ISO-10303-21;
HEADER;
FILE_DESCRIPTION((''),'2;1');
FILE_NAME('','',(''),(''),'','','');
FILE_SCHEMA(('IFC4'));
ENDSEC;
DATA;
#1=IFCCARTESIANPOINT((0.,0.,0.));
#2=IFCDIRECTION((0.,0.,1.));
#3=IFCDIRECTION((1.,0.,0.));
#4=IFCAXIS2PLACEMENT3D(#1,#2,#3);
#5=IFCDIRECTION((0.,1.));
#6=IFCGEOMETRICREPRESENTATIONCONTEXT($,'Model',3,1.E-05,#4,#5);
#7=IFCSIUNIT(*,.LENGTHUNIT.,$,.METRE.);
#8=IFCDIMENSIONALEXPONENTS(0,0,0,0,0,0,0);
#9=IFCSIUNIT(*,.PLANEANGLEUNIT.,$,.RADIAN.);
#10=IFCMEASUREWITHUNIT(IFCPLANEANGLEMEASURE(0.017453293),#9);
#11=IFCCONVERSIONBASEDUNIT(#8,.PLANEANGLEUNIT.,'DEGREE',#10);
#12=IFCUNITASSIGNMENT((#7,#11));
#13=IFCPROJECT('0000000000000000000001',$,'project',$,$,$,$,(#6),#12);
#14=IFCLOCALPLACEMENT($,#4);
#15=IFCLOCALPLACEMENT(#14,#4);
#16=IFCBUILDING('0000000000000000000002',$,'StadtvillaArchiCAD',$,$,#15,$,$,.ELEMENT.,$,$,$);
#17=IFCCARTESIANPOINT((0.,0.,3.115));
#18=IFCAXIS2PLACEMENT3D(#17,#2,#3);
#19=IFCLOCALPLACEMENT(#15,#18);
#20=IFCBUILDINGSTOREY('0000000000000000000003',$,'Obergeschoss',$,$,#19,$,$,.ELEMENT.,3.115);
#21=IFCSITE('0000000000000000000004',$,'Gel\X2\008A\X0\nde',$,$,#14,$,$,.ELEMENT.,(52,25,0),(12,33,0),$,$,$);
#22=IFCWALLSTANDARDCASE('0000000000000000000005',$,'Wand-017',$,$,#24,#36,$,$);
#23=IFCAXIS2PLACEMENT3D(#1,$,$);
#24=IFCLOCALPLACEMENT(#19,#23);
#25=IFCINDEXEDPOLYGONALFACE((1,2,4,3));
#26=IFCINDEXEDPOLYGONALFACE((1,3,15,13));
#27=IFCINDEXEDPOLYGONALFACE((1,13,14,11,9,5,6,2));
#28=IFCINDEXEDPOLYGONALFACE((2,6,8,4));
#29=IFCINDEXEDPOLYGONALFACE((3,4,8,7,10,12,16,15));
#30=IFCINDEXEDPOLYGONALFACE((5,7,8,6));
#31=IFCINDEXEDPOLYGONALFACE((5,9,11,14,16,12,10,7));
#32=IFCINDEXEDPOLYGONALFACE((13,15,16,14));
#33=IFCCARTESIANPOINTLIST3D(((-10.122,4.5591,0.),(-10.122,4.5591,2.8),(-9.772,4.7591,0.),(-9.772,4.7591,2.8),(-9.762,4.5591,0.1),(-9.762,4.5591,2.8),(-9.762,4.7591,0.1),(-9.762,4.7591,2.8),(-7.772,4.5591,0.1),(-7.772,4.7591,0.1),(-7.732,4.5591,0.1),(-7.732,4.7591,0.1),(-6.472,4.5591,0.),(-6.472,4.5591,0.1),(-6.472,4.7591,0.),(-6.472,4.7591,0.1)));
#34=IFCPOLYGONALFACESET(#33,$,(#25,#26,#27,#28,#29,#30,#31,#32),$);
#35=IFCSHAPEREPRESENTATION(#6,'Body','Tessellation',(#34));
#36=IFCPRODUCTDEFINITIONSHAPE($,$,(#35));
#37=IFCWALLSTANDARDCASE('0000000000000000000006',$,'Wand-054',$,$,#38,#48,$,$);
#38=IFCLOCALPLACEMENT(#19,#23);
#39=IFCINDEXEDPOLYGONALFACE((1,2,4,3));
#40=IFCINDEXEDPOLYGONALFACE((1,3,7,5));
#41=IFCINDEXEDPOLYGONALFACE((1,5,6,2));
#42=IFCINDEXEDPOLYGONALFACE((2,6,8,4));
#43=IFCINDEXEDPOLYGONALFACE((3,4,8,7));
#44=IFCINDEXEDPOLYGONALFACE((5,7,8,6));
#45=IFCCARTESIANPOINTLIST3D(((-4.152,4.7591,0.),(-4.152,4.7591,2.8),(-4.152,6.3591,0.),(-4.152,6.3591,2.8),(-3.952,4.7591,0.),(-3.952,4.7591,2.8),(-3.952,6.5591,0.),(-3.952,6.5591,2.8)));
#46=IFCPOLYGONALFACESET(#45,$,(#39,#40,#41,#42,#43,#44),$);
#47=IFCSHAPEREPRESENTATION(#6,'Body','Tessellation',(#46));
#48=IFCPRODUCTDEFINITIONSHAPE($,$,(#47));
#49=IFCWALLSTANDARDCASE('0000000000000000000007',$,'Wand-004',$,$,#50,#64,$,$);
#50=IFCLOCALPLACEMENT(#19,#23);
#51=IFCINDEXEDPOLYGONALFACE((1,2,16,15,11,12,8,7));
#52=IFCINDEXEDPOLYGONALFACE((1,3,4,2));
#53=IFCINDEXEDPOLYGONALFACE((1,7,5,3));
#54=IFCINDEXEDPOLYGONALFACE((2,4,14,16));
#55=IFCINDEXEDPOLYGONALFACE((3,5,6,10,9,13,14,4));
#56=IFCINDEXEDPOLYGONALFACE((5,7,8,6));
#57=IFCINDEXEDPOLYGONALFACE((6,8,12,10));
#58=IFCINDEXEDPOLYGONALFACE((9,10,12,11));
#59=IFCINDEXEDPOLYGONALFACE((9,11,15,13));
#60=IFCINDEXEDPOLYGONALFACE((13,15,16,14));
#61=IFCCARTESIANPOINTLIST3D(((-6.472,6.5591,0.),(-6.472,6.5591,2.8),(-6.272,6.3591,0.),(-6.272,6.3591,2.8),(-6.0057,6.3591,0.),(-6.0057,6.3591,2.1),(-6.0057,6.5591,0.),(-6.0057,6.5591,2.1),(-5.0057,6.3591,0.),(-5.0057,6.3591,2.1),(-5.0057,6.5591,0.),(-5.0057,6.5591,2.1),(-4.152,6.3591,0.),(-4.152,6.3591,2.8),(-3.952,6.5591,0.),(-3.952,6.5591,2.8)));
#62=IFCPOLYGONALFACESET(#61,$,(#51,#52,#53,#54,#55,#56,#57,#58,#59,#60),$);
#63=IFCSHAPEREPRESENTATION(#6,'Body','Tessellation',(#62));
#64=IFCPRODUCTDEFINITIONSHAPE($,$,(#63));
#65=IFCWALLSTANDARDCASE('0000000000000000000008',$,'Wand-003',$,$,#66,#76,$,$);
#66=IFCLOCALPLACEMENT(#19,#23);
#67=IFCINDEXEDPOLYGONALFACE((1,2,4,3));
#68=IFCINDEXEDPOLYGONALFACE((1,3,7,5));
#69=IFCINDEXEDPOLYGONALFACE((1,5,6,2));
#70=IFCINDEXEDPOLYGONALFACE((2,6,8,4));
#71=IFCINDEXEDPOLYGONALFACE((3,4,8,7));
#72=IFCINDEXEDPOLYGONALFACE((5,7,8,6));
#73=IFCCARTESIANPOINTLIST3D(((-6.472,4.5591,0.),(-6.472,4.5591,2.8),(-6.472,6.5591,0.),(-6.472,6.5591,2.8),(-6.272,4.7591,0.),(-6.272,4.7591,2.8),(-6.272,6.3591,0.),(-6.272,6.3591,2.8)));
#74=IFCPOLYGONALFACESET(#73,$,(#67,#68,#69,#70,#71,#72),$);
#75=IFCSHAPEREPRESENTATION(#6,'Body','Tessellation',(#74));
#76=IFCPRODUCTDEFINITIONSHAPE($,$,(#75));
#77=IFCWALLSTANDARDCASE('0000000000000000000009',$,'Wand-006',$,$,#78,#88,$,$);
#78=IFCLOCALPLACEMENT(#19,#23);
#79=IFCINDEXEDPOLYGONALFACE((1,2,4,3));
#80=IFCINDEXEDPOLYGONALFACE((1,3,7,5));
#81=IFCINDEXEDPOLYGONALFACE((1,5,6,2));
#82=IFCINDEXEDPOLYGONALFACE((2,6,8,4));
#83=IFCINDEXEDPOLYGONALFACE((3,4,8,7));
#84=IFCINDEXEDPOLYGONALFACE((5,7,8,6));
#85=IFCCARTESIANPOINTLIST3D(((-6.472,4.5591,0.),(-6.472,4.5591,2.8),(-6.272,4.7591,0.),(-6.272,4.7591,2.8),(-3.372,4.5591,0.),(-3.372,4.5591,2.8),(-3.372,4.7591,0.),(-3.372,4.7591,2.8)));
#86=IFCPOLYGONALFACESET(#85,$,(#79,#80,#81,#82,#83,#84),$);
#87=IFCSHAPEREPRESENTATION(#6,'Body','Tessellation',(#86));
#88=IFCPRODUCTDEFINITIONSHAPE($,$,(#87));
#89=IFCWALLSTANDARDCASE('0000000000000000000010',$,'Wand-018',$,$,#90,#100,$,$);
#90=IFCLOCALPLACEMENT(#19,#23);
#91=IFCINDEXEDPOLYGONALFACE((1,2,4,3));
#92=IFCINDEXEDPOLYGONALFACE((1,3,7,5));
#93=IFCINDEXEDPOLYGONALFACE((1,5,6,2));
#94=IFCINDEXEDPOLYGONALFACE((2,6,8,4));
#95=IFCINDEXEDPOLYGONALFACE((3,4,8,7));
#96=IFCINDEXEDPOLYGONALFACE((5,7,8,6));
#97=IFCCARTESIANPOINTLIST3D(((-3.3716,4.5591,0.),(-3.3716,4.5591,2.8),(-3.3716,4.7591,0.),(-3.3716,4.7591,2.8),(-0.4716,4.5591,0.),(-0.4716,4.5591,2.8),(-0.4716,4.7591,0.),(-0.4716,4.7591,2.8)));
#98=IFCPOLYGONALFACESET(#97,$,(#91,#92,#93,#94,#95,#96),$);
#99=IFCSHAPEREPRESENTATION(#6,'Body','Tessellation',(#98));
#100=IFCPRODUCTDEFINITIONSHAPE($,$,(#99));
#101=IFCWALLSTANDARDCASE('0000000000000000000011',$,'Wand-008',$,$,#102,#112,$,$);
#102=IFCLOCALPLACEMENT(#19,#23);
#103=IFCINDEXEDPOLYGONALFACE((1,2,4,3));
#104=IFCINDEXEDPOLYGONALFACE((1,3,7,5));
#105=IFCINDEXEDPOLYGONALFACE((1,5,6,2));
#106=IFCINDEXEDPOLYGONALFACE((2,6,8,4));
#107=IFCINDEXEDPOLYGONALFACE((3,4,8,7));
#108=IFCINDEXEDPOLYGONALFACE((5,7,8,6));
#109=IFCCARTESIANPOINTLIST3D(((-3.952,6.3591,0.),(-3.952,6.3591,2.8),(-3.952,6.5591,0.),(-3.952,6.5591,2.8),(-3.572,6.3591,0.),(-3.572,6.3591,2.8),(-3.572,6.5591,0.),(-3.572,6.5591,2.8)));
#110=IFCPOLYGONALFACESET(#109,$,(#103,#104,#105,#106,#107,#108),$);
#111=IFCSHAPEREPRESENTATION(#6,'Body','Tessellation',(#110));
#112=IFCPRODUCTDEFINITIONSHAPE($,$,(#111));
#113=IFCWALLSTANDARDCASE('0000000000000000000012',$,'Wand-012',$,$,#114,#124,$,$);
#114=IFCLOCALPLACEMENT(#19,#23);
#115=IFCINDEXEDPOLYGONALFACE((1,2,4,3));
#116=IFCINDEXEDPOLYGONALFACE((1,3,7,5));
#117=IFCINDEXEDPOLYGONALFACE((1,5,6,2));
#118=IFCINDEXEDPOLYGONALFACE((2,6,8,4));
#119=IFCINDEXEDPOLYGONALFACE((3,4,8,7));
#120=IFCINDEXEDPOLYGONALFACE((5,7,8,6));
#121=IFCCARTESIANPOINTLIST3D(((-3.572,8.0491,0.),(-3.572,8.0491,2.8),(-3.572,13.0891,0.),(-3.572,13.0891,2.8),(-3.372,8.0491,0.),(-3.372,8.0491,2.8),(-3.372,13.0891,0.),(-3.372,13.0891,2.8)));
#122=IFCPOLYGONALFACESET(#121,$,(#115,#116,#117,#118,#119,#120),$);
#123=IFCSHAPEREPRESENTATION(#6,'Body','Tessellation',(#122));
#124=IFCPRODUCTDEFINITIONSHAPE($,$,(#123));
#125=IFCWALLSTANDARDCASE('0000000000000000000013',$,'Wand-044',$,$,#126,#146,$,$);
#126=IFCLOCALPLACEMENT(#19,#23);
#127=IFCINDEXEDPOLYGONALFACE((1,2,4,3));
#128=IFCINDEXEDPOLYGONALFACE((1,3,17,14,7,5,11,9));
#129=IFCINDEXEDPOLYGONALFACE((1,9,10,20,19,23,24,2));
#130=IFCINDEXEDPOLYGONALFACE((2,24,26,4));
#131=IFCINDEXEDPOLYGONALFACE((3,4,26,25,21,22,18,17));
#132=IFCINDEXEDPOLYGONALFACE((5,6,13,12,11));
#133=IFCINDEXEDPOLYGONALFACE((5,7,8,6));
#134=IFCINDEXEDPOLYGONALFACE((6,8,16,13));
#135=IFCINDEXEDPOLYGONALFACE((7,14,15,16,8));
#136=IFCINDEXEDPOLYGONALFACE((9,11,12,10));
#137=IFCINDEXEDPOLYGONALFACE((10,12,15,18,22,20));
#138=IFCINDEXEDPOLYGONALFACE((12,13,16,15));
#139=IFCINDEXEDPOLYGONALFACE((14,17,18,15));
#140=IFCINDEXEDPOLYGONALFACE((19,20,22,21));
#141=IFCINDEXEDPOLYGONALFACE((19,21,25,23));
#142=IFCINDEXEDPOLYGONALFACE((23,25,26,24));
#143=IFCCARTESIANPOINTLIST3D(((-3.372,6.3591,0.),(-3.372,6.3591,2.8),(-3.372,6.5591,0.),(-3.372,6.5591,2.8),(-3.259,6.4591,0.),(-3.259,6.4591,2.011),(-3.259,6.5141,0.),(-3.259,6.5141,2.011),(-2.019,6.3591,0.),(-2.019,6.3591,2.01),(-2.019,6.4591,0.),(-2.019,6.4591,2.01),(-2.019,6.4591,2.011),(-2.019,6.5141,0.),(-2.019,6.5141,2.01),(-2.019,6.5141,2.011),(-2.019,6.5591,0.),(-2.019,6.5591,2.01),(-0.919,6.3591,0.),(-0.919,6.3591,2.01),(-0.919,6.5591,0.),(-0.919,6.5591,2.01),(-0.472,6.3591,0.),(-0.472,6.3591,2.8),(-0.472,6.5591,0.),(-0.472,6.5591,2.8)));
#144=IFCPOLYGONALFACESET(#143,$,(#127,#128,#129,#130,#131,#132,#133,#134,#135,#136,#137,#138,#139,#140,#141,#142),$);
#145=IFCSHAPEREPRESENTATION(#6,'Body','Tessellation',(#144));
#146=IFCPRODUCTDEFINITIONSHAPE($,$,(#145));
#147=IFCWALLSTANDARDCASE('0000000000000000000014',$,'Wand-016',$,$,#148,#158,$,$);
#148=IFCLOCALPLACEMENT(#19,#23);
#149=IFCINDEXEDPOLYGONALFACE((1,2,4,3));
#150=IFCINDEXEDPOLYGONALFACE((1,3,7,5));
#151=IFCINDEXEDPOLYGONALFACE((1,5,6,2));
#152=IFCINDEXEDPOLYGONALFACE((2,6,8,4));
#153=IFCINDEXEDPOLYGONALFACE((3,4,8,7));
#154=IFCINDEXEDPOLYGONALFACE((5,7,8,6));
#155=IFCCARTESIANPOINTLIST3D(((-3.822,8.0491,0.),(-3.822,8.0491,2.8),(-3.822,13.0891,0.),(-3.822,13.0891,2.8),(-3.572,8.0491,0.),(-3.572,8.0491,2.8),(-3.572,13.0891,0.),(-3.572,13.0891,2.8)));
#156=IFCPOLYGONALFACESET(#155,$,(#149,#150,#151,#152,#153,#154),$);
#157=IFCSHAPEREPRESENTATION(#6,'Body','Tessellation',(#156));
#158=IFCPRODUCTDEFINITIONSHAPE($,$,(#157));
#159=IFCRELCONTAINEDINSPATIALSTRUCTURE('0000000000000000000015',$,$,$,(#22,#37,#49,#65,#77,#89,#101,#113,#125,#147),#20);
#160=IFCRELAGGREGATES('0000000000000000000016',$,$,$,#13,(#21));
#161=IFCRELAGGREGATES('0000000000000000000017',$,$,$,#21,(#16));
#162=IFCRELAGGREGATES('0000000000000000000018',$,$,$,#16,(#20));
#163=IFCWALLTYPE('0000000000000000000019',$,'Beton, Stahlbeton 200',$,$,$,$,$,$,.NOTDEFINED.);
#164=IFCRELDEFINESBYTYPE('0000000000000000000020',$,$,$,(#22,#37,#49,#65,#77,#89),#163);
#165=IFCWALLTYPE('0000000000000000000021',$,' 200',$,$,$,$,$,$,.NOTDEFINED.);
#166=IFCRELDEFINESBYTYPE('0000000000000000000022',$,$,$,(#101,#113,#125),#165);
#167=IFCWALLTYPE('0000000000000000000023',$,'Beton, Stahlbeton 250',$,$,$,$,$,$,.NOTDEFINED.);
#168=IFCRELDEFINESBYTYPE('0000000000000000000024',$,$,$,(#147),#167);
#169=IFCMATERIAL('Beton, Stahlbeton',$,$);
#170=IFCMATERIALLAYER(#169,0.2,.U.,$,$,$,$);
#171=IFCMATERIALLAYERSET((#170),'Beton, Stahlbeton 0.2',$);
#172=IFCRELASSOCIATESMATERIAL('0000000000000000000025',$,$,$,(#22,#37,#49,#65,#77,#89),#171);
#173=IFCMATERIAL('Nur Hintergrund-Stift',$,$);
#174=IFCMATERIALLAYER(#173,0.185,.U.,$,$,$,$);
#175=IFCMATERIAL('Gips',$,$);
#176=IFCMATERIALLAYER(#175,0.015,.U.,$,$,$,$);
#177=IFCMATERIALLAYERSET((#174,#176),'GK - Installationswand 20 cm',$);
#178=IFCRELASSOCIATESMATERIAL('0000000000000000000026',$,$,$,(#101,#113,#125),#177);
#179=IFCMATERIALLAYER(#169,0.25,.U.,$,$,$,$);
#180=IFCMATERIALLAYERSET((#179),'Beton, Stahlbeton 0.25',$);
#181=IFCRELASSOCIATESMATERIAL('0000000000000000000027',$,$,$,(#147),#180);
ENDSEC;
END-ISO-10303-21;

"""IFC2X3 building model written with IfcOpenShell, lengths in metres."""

from ifc_helpers import new_model, entity, si_unit, converted_unit, direction, frame, origin_with_axes, origin_2d_with_axis, place, context, project, spatial, polyline, rectangle, outline, extrude, material, layer, layer_set, layer_usage, type_object, element, save


model = new_model("IFC2X3")

# Units and contexts
model_context = context("Model", 3, precision=1e-05, world=origin_with_axes(), true_north=direction((0.0, 1.0)))
ifc_project = project(units=[si_unit("LENGTHUNIT", "METRE"), converted_unit("PLANEANGLEUNIT", "DEGREE", entity("IfcPlaneAngleMeasure", 0.017453293), si_unit("PLANEANGLEUNIT", "RADIAN"), dimensions=[0, 0, 0, 0, 0, 0, 0])], contexts=[model_context])

# Site, building, storey
site_placement = place(None, origin_with_axes())
site = spatial("IfcSite", under=ifc_project, at=site_placement, Name="Gel\u008ande", CompositionType="ELEMENT", RefLatitude=(52, 25, 0), RefLongitude=(12, 33, 0))
building_placement = place(site_placement, origin_with_axes())
building = spatial("IfcBuilding", under=site, at=building_placement, Name="StadtvillaArchiCAD", CompositionType="ELEMENT")
storey_placement = place(building_placement, frame((0.0, 0.0, 3.115), z_axis=(0.0, 0.0, 1.0), x_axis=(1.0, 0.0, 0.0)))
storey = spatial("IfcBuildingStorey", under=building, at=storey_placement, Name="Obergeschoss", CompositionType="ELEMENT", Elevation=3.115)

# Wall, openings
ifc_material_1 = material(Name="Beton, Stahlbeton")
ifc_layer_1 = layer(ifc_material_1, 0.2, ventilated="UNKNOWN")
ifc_layer_set_1 = layer_set([ifc_layer_1], Name="Beton, Stahlbeton 0.2")
ifc_layer_usage_1 = layer_usage(ifc_layer_set_1, "AXIS2", "NEGATIVE", 0.0)
wall_type_1 = type_object("IfcWallType", Name="Beton, Stahlbeton 200", PredefinedType="NOTDEFINED")
wall_1_placement = place(storey_placement, frame((-6.472, 4.5591, 0.0), z_axis=(0.0, 0.0, 1.0), x_axis=(-1.0, 0.0, 0.0)))
wall_1 = element("IfcWallStandardCase", 1, at=wall_1_placement, inside=storey, type_object=wall_type_1, material=ifc_layer_usage_1, Name="Wand-017", context=model_context, shape_type="SweptSolid", body=[
    extrude(outline(polyline([(0.0, -0.2), (3.3, -0.2), (3.65, 0.0), (0.0, 0.0), (0.0, -0.2)])), origin_with_axes(), (0.0, 0.0, 1.0), 2.8),
])
opening_1_placement = place(wall_1_placement, frame((2.275, 0.0, 0.1), z_axis=(0.0, 0.0, 1.0), x_axis=(1.0, 0.0, 0.0)))
element("IfcOpeningElement", 2, at=opening_1_placement, cuts=wall_1, context=model_context, shape_type="SweptSolid", body=[
    extrude(rectangle(XDim=2.03, YDim=2.7, at=origin_2d_with_axis()), frame((0.0, -0.201, 1.35), z_axis=(0.0, 1.0, 0.0), x_axis=(1.0, 0.0, 0.0)), (0.0, 0.0, 1.0), 0.602),
])
opening_2_placement = place(wall_1_placement, frame((0.65, 0.0, 0.1), z_axis=(0.0, 0.0, 1.0), x_axis=(1.0, 0.0, 0.0)))
element("IfcOpeningElement", 3, at=opening_2_placement, cuts=wall_1, context=model_context, shape_type="SweptSolid", body=[
    extrude(rectangle(XDim=1.3, YDim=2.7, at=origin_2d_with_axis()), frame((0.0, -0.201, 1.35), z_axis=(0.0, 1.0, 0.0), x_axis=(1.0, 0.0, 0.0)), (0.0, 0.0, 1.0), 0.602),
])

# Wall
ifc_layer_usage_2 = layer_usage(ifc_layer_set_1, "AXIS2", "NEGATIVE", 0.0)
wall_2_placement = place(storey_placement, frame((-3.952, 6.5591, 0.0), z_axis=(0.0, 0.0, 1.0), x_axis=(0.0, -1.0, 0.0)))
element("IfcWallStandardCase", 4, at=wall_2_placement, inside=storey, type_object=wall_type_1, material=ifc_layer_usage_2, Name="Wand-054", context=model_context, shape_type="SweptSolid", body=[
    extrude(outline(polyline([(0.2, -0.2), (1.8, -0.2), (1.8, 0.0), (0.0, 0.0), (0.2, -0.2)])), origin_with_axes(), (0.0, 0.0, 1.0), 2.8),
])

# Wall, opening
ifc_layer_usage_3 = layer_usage(ifc_layer_set_1, "AXIS2", "NEGATIVE", 0.0)
wall_3_placement = place(storey_placement, frame((-6.472, 6.5591, 0.0), z_axis=(0.0, 0.0, 1.0), x_axis=(1.0, 0.0, 0.0)))
wall_3 = element("IfcWallStandardCase", 5, at=wall_3_placement, inside=storey, type_object=wall_type_1, material=ifc_layer_usage_3, Name="Wand-004", context=model_context, shape_type="SweptSolid", body=[
    extrude(outline(polyline([(0.2, -0.2), (2.32, -0.2), (2.52, 0.0), (0.0, 0.0), (0.2, -0.2)])), origin_with_axes(), (0.0, 0.0, 1.0), 2.8),
])
opening_3_placement = place(wall_3_placement, frame((0.9662, 0.0, 0.0), z_axis=(0.0, 0.0, 1.0), x_axis=(1.0, 0.0, 0.0)))
element("IfcOpeningElement", 6, at=opening_3_placement, cuts=wall_3, context=model_context, shape_type="SweptSolid", body=[
    extrude(rectangle(XDim=1.0, YDim=2.1, at=origin_2d_with_axis()), frame((0.0, -1.8, 1.05), z_axis=(0.0, 1.0, 0.0), x_axis=(1.0, 0.0, 0.0)), (0.0, 0.0, 1.0), 3.2),
])

# Walls
ifc_layer_usage_4 = layer_usage(ifc_layer_set_1, "AXIS2", "NEGATIVE", 0.0)
wall_4_placement = place(storey_placement, frame((-6.472, 4.5591, 0.0), z_axis=(0.0, 0.0, 1.0), x_axis=(0.0, 1.0, 0.0)))
element("IfcWallStandardCase", 7, at=wall_4_placement, inside=storey, type_object=wall_type_1, material=ifc_layer_usage_4, Name="Wand-003", context=model_context, shape_type="SweptSolid", body=[
    extrude(outline(polyline([(0.2, -0.2), (1.8, -0.2), (2.0, 0.0), (0.0, 0.0), (0.2, -0.2)])), origin_with_axes(), (0.0, 0.0, 1.0), 2.8),
])
ifc_layer_usage_5 = layer_usage(ifc_layer_set_1, "AXIS2", "NEGATIVE", 0.0)
wall_5_placement = place(storey_placement, frame((-3.372, 4.5591, 0.0), z_axis=(0.0, 0.0, 1.0), x_axis=(-1.0, 0.0, 0.0)))
element("IfcWallStandardCase", 8, at=wall_5_placement, inside=storey, type_object=wall_type_1, material=ifc_layer_usage_5, Name="Wand-006", context=model_context, shape_type="SweptSolid", body=[
    extrude(outline(polyline([(0.0, -0.2), (2.9, -0.2), (3.1, 0.0), (0.0, 0.0), (0.0, -0.2)])), origin_with_axes(), (0.0, 0.0, 1.0), 2.8),
])
ifc_layer_usage_6 = layer_usage(ifc_layer_set_1, "AXIS2", "NEGATIVE", 0.0)
wall_6_placement = place(storey_placement, frame((-3.3716, 4.7591, 0.0), z_axis=(0.0, 0.0, 1.0), x_axis=(1.0, 0.0, 0.0)))
element("IfcWallStandardCase", 9, at=wall_6_placement, inside=storey, type_object=wall_type_1, material=ifc_layer_usage_6, Name="Wand-018", context=model_context, shape_type="SweptSolid", body=[
    extrude(outline(polyline([(0.0, -0.2), (2.9, -0.2), (2.9, 0.0), (0.0, 0.0), (0.0, -0.2)])), origin_with_axes(), (0.0, 0.0, 1.0), 2.8),
])

# Walls
ifc_material_2 = material(Name="Nur Hintergrund-Stift")
ifc_layer_2 = layer(ifc_material_2, 0.185, ventilated="UNKNOWN")
ifc_material_3 = material(Name="Gips")
ifc_layer_3 = layer(ifc_material_3, 0.015, ventilated="UNKNOWN")
ifc_layer_set_2 = layer_set([ifc_layer_2, ifc_layer_3], Name="GK - Installationswand 20 cm")
wall_type_2 = type_object("IfcWallType", Name=" 200", PredefinedType="NOTDEFINED")
ifc_layer_usage_7 = layer_usage(ifc_layer_set_2, "AXIS2", "NEGATIVE", 0.0)
wall_7_placement = place(storey_placement, frame((-3.572, 6.3591, 0.0), z_axis=(0.0, 0.0, 1.0), x_axis=(-1.0, 0.0, 0.0)))
element("IfcWallStandardCase", 10, at=wall_7_placement, inside=storey, type_object=wall_type_2, material=ifc_layer_usage_7, Name="Wand-008", context=model_context, shape_type="SweptSolid", body=[
    extrude(outline(polyline([(0.0, -0.2), (0.38, -0.2), (0.38, 0.0), (0.0, 0.0), (0.0, -0.2)])), origin_with_axes(), (0.0, 0.0, 1.0), 2.8),
])
ifc_layer_usage_8 = layer_usage(ifc_layer_set_2, "AXIS2", "NEGATIVE", 0.0)
wall_8_placement = place(storey_placement, frame((-3.572, 8.0491, 0.0), z_axis=(0.0, 0.0, 1.0), x_axis=(0.0, 1.0, 0.0)))
element("IfcWallStandardCase", 11, at=wall_8_placement, inside=storey, type_object=wall_type_2, material=ifc_layer_usage_8, Name="Wand-012", context=model_context, shape_type="SweptSolid", body=[
    extrude(outline(polyline([(0.0, -0.2), (5.04, -0.2), (5.04, 0.0), (0.0, 0.0), (0.0, -0.2)])), origin_with_axes(), (0.0, 0.0, 1.0), 2.8),
])

# Wall, opening
ifc_layer_usage_9 = layer_usage(ifc_layer_set_2, "AXIS2", "NEGATIVE", 0.0)
wall_9_placement = place(storey_placement, frame((-3.372, 6.5591, 0.0), z_axis=(0.0, 0.0, 1.0), x_axis=(1.0, 0.0, 0.0)))
wall_9 = element("IfcWallStandardCase", 12, at=wall_9_placement, inside=storey, type_object=wall_type_2, material=ifc_layer_usage_9, Name="Wand-044", context=model_context, shape_type="SweptSolid", body=[
    extrude(outline(polyline([(0.0, -0.2), (2.9, -0.2), (2.9, 0.0), (0.0, 0.0), (0.0, -0.2)])), origin_with_axes(), (0.0, 0.0, 1.0), 2.8),
])
opening_4_placement = place(wall_9_placement, frame((1.9029, 0.0, 0.0), z_axis=(0.0, 0.0, 1.0), x_axis=(1.0, 0.0, 0.0)))
element("IfcOpeningElement", 13, at=opening_4_placement, cuts=wall_9, context=model_context, shape_type="SweptSolid", body=[
    extrude(rectangle(XDim=1.1, YDim=2.01, at=origin_2d_with_axis()), frame((0.0, 0.001, 1.005), z_axis=(0.0, -1.0, 0.0), x_axis=(1.0, 0.0, 0.0)), (0.0, 0.0, 1.0), 0.602),
    extrude(outline(polyline([(-0.55, -0.1), (-0.55, -0.045), (-1.79, -0.045), (-1.79, -0.1), (-0.55, -0.1)])), frame((0.0, 0.0, -0.001), z_axis=(0.0, 0.0, 1.0), x_axis=(1.0, 0.0, 0.0)), (0.0, 0.0, 1.0), 2.012),
])

# Wall
ifc_layer_4 = layer(ifc_material_1, 0.25, ventilated="UNKNOWN")
ifc_layer_set_3 = layer_set([ifc_layer_4], Name="Beton, Stahlbeton 0.25")
ifc_layer_usage_10 = layer_usage(ifc_layer_set_3, "AXIS2", "NEGATIVE", 0.0)
wall_type_3 = type_object("IfcWallType", Name="Beton, Stahlbeton 250", PredefinedType="NOTDEFINED")
wall_10_placement = place(storey_placement, frame((-3.822, 8.0491, 0.0), z_axis=(0.0, 0.0, 1.0), x_axis=(0.0, 1.0, 0.0)))
element("IfcWallStandardCase", 14, at=wall_10_placement, inside=storey, type_object=wall_type_3, material=ifc_layer_usage_10, Name="Wand-016", context=model_context, shape_type="SweptSolid", body=[
    extrude(outline(polyline([(0.0, -0.25), (5.04, -0.25), (5.04, 0.0), (0.0, 0.0), (0.0, -0.25)])), origin_with_axes(), (0.0, 0.0, 1.0), 2.8),
])

save(model, "model.ifc")
